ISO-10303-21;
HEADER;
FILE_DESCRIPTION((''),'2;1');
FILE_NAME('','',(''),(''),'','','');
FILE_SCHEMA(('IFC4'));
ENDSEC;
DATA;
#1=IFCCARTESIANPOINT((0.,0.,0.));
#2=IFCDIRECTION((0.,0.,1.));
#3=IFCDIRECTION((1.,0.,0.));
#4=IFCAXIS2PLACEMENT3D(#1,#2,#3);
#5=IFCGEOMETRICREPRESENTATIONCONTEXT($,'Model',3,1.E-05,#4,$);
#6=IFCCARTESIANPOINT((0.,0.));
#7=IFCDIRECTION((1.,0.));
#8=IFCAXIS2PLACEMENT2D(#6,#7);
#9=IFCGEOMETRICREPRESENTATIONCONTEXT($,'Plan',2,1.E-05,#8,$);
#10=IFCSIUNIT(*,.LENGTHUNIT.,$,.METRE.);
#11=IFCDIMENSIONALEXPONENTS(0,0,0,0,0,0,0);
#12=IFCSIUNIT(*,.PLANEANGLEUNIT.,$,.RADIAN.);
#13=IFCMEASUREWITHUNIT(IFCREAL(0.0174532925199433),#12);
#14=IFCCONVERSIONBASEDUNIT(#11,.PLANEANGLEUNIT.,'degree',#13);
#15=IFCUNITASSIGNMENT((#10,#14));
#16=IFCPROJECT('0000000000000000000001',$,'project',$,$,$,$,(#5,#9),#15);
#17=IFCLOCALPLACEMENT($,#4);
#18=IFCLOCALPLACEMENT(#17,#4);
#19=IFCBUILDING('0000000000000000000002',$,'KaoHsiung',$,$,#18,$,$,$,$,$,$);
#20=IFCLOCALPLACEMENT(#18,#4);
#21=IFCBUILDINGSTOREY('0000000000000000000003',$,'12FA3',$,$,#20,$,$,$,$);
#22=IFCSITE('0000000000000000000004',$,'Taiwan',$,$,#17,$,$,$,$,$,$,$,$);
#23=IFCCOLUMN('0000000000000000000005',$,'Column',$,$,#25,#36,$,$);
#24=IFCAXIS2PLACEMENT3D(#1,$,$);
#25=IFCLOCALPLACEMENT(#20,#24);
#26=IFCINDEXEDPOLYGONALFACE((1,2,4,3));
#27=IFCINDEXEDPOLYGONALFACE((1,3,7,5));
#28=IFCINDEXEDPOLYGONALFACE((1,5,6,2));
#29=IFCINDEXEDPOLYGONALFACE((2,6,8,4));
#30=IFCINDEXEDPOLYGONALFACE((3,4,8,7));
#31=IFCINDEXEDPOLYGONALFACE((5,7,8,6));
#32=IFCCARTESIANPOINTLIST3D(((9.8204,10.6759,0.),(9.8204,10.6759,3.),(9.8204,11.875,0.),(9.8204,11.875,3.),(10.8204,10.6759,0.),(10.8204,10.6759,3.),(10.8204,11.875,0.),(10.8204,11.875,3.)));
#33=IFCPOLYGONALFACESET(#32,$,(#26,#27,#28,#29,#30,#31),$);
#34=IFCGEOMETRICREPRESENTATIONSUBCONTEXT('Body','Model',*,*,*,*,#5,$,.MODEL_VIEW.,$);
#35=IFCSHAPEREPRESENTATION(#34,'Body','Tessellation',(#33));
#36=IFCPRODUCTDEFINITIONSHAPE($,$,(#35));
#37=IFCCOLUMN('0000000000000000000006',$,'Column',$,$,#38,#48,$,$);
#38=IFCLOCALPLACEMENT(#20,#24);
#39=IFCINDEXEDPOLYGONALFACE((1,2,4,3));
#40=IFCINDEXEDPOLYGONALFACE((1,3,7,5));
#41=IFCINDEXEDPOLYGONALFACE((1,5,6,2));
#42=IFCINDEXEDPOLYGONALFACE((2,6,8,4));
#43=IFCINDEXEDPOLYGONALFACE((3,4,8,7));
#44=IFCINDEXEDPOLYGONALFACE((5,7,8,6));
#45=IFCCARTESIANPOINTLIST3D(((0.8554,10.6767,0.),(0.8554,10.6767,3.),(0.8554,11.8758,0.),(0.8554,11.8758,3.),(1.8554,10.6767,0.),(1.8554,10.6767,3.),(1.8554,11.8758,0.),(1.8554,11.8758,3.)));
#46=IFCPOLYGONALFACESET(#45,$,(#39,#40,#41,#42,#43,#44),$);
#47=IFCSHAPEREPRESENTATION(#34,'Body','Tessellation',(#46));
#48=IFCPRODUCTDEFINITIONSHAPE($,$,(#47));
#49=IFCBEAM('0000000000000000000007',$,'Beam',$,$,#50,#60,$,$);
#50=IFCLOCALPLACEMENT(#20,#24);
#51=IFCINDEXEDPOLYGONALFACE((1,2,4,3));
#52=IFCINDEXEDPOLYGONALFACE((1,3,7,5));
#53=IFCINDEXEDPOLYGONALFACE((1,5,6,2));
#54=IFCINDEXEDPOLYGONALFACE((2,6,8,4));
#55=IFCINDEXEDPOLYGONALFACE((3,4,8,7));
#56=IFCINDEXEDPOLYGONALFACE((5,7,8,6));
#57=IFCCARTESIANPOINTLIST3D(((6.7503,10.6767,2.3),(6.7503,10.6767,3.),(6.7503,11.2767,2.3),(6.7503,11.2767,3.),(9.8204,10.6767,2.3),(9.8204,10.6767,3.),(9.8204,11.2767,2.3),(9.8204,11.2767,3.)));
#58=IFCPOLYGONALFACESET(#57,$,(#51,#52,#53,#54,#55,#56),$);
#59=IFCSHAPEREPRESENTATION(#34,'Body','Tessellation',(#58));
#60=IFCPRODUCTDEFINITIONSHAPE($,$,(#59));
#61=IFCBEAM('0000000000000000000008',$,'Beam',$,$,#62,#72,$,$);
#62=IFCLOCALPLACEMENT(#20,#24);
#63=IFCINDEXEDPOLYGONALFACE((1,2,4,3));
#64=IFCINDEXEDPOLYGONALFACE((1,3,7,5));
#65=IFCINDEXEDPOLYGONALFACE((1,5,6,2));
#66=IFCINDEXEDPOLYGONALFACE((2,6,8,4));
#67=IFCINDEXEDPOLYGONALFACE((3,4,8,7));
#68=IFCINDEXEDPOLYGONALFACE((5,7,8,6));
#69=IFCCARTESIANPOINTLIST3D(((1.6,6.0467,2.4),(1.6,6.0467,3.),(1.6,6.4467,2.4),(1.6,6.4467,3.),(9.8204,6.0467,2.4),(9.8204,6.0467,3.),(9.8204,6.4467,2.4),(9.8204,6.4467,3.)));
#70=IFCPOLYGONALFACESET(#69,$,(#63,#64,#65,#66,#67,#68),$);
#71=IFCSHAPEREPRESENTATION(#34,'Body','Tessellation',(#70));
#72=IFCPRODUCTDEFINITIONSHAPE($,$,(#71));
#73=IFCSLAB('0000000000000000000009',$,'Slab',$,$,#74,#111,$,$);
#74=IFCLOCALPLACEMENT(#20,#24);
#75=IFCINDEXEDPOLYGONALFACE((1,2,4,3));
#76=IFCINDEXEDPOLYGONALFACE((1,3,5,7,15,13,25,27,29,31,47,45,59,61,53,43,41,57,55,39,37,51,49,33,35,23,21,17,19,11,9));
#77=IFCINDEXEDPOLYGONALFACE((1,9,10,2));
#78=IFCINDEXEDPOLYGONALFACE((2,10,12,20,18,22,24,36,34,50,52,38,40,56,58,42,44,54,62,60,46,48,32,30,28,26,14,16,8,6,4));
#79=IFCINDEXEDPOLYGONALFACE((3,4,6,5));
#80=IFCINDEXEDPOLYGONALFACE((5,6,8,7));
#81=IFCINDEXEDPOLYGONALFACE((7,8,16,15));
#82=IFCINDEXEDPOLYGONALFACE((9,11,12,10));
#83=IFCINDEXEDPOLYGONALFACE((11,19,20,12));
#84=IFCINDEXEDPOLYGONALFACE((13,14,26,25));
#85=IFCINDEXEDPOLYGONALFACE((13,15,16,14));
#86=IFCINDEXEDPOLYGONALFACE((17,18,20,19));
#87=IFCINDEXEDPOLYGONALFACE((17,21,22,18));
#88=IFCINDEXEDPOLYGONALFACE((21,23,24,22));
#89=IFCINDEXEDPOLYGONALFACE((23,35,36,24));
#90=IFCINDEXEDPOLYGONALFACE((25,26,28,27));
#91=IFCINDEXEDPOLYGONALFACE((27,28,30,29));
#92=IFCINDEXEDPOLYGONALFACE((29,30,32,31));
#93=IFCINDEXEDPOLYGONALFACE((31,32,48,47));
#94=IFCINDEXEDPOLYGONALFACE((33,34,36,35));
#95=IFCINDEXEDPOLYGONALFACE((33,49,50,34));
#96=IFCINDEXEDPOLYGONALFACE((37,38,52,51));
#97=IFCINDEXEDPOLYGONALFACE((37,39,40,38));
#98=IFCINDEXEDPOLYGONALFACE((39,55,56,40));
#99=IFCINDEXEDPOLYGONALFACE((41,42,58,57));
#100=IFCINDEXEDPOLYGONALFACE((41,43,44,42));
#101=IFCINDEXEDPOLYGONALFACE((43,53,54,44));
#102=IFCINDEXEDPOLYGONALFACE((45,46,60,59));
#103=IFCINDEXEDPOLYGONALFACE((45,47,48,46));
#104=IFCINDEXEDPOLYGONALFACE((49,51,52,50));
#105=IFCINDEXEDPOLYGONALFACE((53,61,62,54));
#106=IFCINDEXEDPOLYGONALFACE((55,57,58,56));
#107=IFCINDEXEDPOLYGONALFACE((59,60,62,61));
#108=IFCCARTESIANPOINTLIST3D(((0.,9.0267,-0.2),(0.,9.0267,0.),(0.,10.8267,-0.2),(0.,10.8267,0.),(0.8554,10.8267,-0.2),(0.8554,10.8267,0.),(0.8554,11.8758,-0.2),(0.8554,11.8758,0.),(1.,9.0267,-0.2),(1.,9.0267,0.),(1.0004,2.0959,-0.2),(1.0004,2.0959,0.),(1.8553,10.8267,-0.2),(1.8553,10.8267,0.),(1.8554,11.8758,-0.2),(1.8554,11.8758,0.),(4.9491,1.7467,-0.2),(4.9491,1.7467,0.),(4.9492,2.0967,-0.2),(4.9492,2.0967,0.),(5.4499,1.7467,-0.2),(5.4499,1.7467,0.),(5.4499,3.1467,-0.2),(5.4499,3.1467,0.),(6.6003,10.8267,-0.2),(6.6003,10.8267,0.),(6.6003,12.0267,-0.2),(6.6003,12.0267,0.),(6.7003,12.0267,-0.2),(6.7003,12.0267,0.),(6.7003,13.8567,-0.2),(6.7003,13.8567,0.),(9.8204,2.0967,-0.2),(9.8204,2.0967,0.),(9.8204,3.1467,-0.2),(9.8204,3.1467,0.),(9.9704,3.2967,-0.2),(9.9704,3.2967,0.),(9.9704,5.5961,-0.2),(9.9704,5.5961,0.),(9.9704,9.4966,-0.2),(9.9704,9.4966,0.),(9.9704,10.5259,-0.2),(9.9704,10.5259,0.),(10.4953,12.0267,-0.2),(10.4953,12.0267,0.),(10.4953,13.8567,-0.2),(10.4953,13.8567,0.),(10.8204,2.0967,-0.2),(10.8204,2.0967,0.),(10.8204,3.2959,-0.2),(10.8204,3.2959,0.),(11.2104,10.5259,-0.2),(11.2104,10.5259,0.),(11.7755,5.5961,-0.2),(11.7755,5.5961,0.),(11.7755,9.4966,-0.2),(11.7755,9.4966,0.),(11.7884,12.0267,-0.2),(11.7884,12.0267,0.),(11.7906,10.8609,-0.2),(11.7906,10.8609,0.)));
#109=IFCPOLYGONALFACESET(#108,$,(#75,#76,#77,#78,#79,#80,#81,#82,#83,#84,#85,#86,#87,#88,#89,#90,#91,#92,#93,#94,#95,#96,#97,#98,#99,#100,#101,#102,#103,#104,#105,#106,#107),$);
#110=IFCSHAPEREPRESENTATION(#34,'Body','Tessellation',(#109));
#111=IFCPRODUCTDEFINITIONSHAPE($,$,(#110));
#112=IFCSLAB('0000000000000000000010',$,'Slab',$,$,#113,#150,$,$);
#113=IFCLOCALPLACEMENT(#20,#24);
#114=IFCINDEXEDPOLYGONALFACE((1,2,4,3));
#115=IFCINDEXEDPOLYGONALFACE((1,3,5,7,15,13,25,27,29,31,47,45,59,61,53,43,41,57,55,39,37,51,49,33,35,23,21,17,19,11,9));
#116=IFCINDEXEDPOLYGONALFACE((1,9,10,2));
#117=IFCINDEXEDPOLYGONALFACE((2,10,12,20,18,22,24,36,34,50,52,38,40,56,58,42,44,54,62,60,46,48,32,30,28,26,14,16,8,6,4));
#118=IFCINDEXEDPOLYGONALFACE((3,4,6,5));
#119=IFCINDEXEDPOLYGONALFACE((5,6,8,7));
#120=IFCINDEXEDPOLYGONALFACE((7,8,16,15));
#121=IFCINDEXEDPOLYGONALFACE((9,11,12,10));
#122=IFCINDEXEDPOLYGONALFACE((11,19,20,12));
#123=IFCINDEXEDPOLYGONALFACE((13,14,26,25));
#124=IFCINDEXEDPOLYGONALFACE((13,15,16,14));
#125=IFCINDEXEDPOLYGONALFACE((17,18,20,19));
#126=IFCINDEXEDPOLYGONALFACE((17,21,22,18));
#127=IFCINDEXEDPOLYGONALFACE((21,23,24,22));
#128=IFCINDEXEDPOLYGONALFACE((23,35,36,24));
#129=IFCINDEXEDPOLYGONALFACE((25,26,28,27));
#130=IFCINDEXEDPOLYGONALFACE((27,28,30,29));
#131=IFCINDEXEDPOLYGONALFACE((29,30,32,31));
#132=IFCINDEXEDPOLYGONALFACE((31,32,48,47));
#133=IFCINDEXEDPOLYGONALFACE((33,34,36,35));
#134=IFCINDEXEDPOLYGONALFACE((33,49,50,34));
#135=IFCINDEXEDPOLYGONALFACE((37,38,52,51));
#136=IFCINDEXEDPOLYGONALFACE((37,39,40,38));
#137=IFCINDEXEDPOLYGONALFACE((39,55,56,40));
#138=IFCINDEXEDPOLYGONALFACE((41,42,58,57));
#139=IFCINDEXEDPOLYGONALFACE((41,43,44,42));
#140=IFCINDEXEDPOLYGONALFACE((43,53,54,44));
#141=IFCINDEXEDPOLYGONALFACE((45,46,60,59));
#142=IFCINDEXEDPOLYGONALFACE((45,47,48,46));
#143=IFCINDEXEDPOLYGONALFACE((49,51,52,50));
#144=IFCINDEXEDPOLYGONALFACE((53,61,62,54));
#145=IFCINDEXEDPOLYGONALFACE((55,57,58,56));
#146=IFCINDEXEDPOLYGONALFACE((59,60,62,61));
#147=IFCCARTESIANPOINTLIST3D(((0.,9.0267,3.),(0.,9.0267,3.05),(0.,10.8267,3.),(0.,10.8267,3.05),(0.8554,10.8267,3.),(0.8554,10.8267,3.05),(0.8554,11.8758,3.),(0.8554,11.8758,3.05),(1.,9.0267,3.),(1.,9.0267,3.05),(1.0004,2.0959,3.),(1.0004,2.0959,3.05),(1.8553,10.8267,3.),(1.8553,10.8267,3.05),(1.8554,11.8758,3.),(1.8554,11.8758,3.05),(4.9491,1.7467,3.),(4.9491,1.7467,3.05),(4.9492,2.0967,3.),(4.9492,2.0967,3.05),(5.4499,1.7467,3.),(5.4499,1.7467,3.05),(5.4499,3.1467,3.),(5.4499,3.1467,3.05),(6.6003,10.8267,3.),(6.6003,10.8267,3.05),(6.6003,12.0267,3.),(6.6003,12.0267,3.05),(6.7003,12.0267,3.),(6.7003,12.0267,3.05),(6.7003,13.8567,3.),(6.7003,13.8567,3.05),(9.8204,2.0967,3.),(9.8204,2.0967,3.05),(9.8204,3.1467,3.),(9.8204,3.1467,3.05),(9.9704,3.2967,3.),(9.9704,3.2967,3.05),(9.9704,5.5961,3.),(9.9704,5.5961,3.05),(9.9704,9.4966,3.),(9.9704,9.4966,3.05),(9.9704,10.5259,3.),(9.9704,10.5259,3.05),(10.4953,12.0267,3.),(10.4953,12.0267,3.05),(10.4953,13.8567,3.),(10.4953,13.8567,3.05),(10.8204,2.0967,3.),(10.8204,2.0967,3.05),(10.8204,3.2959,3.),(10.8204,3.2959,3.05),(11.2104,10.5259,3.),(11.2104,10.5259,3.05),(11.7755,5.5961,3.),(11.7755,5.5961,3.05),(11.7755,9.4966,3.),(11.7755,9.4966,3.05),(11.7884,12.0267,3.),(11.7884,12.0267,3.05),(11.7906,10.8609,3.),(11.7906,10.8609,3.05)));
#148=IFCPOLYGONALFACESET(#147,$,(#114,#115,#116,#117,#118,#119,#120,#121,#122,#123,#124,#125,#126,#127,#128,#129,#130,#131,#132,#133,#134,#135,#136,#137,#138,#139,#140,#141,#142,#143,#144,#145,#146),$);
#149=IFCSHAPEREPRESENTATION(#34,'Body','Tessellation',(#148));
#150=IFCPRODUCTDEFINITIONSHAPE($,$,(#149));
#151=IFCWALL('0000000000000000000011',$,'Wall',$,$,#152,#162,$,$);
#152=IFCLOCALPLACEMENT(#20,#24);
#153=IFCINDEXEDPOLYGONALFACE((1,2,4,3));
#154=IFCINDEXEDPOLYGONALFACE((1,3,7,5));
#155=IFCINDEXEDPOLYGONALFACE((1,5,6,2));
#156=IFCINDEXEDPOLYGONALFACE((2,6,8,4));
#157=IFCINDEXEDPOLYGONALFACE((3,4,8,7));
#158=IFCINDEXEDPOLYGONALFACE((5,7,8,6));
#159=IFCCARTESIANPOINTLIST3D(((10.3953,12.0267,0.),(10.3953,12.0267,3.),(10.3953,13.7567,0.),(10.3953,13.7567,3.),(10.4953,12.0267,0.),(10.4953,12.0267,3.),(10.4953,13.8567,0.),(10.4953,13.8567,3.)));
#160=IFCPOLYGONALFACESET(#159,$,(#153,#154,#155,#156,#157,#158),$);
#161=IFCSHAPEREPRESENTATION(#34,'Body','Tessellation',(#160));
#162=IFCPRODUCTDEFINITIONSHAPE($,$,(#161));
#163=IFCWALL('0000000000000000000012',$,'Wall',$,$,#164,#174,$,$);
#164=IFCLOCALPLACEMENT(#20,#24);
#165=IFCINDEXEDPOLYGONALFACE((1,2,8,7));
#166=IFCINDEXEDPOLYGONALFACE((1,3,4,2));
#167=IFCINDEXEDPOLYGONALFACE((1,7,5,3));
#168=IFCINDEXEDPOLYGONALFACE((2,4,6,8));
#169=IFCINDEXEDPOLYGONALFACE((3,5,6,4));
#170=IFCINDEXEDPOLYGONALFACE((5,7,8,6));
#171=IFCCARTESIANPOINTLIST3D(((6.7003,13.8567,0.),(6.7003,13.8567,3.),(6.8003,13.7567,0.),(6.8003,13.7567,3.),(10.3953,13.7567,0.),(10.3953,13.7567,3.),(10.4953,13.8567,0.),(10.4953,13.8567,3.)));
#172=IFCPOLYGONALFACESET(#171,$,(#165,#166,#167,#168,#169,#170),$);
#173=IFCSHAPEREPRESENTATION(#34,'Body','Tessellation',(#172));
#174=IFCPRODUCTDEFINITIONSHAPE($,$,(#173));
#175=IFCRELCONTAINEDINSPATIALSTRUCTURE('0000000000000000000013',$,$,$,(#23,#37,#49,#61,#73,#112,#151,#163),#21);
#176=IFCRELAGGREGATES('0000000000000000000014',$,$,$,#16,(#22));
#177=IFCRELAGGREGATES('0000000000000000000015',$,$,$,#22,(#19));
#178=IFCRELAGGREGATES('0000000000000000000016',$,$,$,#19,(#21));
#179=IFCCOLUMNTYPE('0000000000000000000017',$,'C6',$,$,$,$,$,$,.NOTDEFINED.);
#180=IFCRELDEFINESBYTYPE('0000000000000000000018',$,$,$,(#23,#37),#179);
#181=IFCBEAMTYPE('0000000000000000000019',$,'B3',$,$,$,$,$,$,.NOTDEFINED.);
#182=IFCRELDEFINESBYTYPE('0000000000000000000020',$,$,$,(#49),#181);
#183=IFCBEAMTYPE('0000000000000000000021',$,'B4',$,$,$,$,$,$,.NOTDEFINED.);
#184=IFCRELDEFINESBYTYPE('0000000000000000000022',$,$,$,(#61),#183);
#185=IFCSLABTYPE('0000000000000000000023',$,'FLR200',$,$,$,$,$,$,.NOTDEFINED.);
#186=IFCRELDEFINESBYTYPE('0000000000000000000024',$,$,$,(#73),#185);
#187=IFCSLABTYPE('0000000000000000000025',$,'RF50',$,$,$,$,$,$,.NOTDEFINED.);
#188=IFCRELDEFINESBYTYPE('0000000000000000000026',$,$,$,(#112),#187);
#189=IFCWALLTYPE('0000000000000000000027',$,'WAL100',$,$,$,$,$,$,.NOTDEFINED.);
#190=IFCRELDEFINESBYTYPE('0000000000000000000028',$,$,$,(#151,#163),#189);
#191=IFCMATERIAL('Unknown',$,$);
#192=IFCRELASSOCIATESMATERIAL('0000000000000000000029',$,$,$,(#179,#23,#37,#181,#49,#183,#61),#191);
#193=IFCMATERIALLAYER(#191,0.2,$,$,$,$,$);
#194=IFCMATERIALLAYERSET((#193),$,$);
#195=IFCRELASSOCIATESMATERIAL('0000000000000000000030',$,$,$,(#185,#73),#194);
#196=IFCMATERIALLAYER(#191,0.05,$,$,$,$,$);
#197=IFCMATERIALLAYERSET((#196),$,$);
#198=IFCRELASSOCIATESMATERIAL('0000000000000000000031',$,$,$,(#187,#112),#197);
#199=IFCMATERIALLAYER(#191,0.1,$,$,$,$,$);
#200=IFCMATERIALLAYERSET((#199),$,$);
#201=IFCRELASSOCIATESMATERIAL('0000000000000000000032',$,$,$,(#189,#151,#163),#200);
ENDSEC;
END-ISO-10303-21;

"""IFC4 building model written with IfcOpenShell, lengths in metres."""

from ifc_helpers import new_model, entity, si_unit, converted_unit, frame, origin_with_axes, origin_2d_with_axis, place, context, subcontext, project, spatial, line, indexed_curve, rectangle, outline, extrude, material, layer, layer_set, layer_usage, material_profile, profile_set, profile_usage, type_object, element, save


model = new_model("IFC4")

# Units and contexts
model_context = context("Model", 3, precision=1e-05, world=origin_with_axes())
plan_context = context("Plan", 2, precision=1e-05, world=origin_2d_with_axis())
body_context = subcontext(model_context, "Body", "Model", "MODEL_VIEW")
ifc_project = project(units=[si_unit("LENGTHUNIT", "METRE"), converted_unit("PLANEANGLEUNIT", "degree", entity("IfcReal", 0.0174532925199433), si_unit("PLANEANGLEUNIT", "RADIAN"), dimensions=[0, 0, 0, 0, 0, 0, 0])], contexts=[model_context, plan_context])

# Site, building, storey
site_placement = place(None, origin_with_axes())
site = spatial("IfcSite", under=ifc_project, at=site_placement, Name="Taiwan")
building_placement = place(site_placement, origin_with_axes())
building = spatial("IfcBuilding", under=site, at=building_placement, Name="KaoHsiung")
storey_placement = place(building_placement, origin_with_axes())
storey = spatial("IfcBuildingStorey", under=building, at=storey_placement, Name="12FA3")

# Columns
ifc_material = material(Name="Unknown")
ifc_material_profile_1 = material_profile(ifc_material, outline(indexed_curve([(0.0, 1.1992), (1.0, 1.1992), (1.0, 0.0), (0.0, 0.0), (0.0, 1.1992)])))
ifc_profile_set_1 = profile_set([ifc_material_profile_1])
ifc_profile_usage_1 = profile_usage(ifc_profile_set_1, cardinal=5)
column_type = type_object("IfcColumnType", Name="C6", PredefinedType="NOTDEFINED", material=ifc_profile_set_1)
column_1_placement = place(storey_placement, frame((9.8204, 10.6759, 0.0), z_axis=(0.0, 0.0, 1.0), x_axis=(1.0, 0.0, 0.0)))
element("IfcColumn", 1, at=column_1_placement, inside=storey, type_object=column_type, material=ifc_profile_usage_1, Name="Column", context=body_context, shape_type="SweptSolid", body=[
    extrude(outline(indexed_curve([(0.0, 1.1992), (1.0, 1.1992), (1.0, 0.0), (0.0, 0.0), (0.0, 1.1992)])), origin_with_axes(), (0.0, 0.0, 1.0), 3.0),
])
ifc_profile_usage_2 = profile_usage(ifc_profile_set_1, cardinal=5)
column_2_placement = place(storey_placement, frame((0.8554, 10.6767, 0.0), z_axis=(0.0, 0.0, 1.0), x_axis=(1.0, 0.0, 0.0)))
element("IfcColumn", 2, at=column_2_placement, inside=storey, type_object=column_type, material=ifc_profile_usage_2, Name="Column", context=body_context, shape_type="SweptSolid", body=[
    extrude(outline(indexed_curve([(0.0, 1.1992), (1.0, 1.1992), (1.0, 0.0), (0.0, 0.0), (0.0, 1.1992)])), origin_with_axes(), (0.0, 0.0, 1.0), 3.0),
])

# Beams
ifc_material_profile_2 = material_profile(ifc_material, rectangle(XDim=0.6, YDim=0.7, kind="CURVE"))
ifc_profile_set_2 = profile_set([ifc_material_profile_2])
ifc_profile_usage_3 = profile_usage(ifc_profile_set_2, cardinal=9)
beam_type_1 = type_object("IfcBeamType", Name="B3", PredefinedType="NOTDEFINED", material=ifc_profile_set_2)
beam_1_placement = place(storey_placement, frame((6.7503, 10.6767, 3.0), z_axis=(1.0, 0.0, 0.0), x_axis=(0.0, 1.0, 0.0)))
element("IfcBeam", 3, at=beam_1_placement, inside=storey, type_object=beam_type_1, material=ifc_profile_usage_3, Name="Beam", context=body_context, shape_type="SweptSolid", body=[
    extrude(rectangle(XDim=0.6, YDim=0.7, kind="CURVE"), frame((0.3, -0.35, 0.0), z_axis=(0.0, 0.0, 1.0), x_axis=(1.0, 0.0, 0.0)), (0.0, 0.0, 1.0), 3.0701),
])
ifc_material_profile_3 = material_profile(ifc_material, rectangle(XDim=0.4, YDim=0.6, kind="CURVE"))
ifc_profile_set_3 = profile_set([ifc_material_profile_3])
ifc_profile_usage_4 = profile_usage(ifc_profile_set_3, cardinal=7)
beam_type_2 = type_object("IfcBeamType", Name="B4", PredefinedType="NOTDEFINED", material=ifc_profile_set_3)
beam_2_placement = place(storey_placement, frame((1.6, 6.4467, 3.0), z_axis=(1.0, 0.0, 0.0), x_axis=(0.0, 1.0, 0.0)))
element("IfcBeam", 4, at=beam_2_placement, inside=storey, type_object=beam_type_2, material=ifc_profile_usage_4, Name="Beam", context=body_context, shape_type="SweptSolid", body=[
    extrude(rectangle(XDim=0.4, YDim=0.6, kind="CURVE"), frame((-0.2, -0.3, 0.0), z_axis=(0.0, 0.0, 1.0), x_axis=(1.0, 0.0, 0.0)), (0.0, 0.0, 1.0), 8.2203),
])

# Slabs
ifc_layer_1 = layer(ifc_material, 0.2)
ifc_layer_set_1 = layer_set([ifc_layer_1])
ifc_layer_usage_1 = layer_usage(ifc_layer_set_1, "AXIS3", "POSITIVE", -0.2)
slab_type_1 = type_object("IfcSlabType", Name="FLR200", PredefinedType="NOTDEFINED", material=ifc_layer_set_1)
slab_1_placement = place(storey_placement, frame((0.0, 10.8267, 0.0), z_axis=(0.0, 0.0, 1.0), x_axis=(1.0, 0.0, 0.0)))
element("IfcSlab", 5, at=slab_1_placement, inside=storey, type_object=slab_type_1, material=ifc_layer_usage_1, Name="Slab", context=body_context, shape_type="SweptSolid", body=[
    extrude(outline(indexed_curve([(0.0, 0.0), (0.0, -1.8), (1.0, -1.8), (1.0004, -8.7308), (4.9492, -8.73), (4.9491, -9.08), (5.4499, -9.08), (5.4499, -7.68), (9.8203, -7.68), (9.8203, -8.73), (10.8203, -8.73), (10.8203, -7.5308), (9.9703, -7.53), (9.9703, -5.2306), (11.7754, -5.2306), (11.7754, -1.3301), (9.9703, -1.3301), (9.9703, -0.3008), (11.2103, -0.3008), (11.7906, 0.0342), (11.7884, 1.2), (10.4952, 1.2), (10.4952, 3.03), (6.7002, 3.03), (6.7002, 1.2001), (6.6003, 1.2), (6.6003, 0.0), (1.8552, 0.0), (1.8553, 1.0492), (0.8553, 1.0492), (0.8553, 0.0), (0.0, 0.0)])), frame((0.0, 0.0, -0.2), z_axis=(0.0, 0.0, 1.0), x_axis=(1.0, 0.0, 0.0)), (0.0, 0.0, 1.0), 0.2),
])
ifc_layer_2 = layer(ifc_material, 0.05)
ifc_layer_set_2 = layer_set([ifc_layer_2])
ifc_layer_usage_2 = layer_usage(ifc_layer_set_2, "AXIS3", "POSITIVE", 0.0)
slab_type_2 = type_object("IfcSlabType", Name="RF50", PredefinedType="NOTDEFINED", material=ifc_layer_set_2)
slab_2_placement = place(storey_placement, frame((0.0, 10.8267, 3.0), z_axis=(0.0, 0.0, 1.0), x_axis=(1.0, 0.0, 0.0)))
element("IfcSlab", 6, at=slab_2_placement, inside=storey, type_object=slab_type_2, material=ifc_layer_usage_2, Name="Slab", context=body_context, shape_type="SweptSolid", body=[
    extrude(outline(indexed_curve([(0.0, 0.0), (0.0, -1.8), (1.0, -1.8), (1.0004, -8.7308), (4.9492, -8.73), (4.9491, -9.08), (5.4499, -9.08), (5.4499, -7.68), (9.8203, -7.68), (9.8203, -8.73), (10.8203, -8.73), (10.8203, -7.5308), (9.9703, -7.53), (9.9703, -5.2306), (11.7754, -5.2306), (11.7754, -1.3301), (9.9703, -1.3301), (9.9703, -0.3008), (11.2103, -0.3008), (11.7906, 0.0342), (11.7884, 1.2), (10.4952, 1.2), (10.4952, 3.03), (6.7002, 3.03), (6.7002, 1.2001), (6.6003, 1.2), (6.6003, 0.0), (1.8552, 0.0), (1.8553, 1.0492), (0.8553, 1.0492), (0.8553, 0.0), (0.0, 0.0)])), None, (0.0, 0.0, 1.0), 0.05),
])

# Walls
ifc_layer_3 = layer(ifc_material, 0.1)
ifc_layer_set_3 = layer_set([ifc_layer_3])
ifc_layer_usage_3 = layer_usage(ifc_layer_set_3, "AXIS2", "POSITIVE", 0.0)
wall_type_1 = type_object("IfcWallType", Name="WAL100", PredefinedType="NOTDEFINED", material=ifc_layer_set_3)
wall_1_placement = place(storey_placement, frame((10.4953, 12.0267, 0.0), z_axis=(0.0, 0.0, 1.0), x_axis=(0.0, 1.0, 0.0)))
element("IfcWall", 7, at=wall_1_placement, inside=storey, type_object=wall_type_1, material=ifc_layer_usage_3, Name="Wall", context=body_context, shape_type="SweptSolid", body=[
    extrude(outline(indexed_curve([(0.0, 0.0), (0.0, 0.1), (1.73, 0.1), (1.83, 0.0)], segments=[line(1, 2, 3, 4, 1)])), origin_with_axes(), (0.0, 0.0, 1.0), 3.0),
])
ifc_layer_usage_4 = layer_usage(ifc_layer_set_3, "AXIS2", "POSITIVE", 0.0)
wall_2_placement = place(storey_placement, frame((10.4953, 13.8567, 0.0), z_axis=(0.0, 0.0, 1.0), x_axis=(-1.0, 0.0, 0.0)))
element("IfcWall", 8, at=wall_2_placement, inside=storey, type_object=wall_type_1, material=ifc_layer_usage_4, Name="Wall", context=body_context, shape_type="SweptSolid", body=[
    extrude(outline(indexed_curve([(0.0, 0.0), (0.1, 0.1), (3.695, 0.1), (3.795, 0.0)], segments=[line(1, 2, 3, 4, 1)])), origin_with_axes(), (0.0, 0.0, 1.0), 3.0),
])

save(model, "model.ifc")
